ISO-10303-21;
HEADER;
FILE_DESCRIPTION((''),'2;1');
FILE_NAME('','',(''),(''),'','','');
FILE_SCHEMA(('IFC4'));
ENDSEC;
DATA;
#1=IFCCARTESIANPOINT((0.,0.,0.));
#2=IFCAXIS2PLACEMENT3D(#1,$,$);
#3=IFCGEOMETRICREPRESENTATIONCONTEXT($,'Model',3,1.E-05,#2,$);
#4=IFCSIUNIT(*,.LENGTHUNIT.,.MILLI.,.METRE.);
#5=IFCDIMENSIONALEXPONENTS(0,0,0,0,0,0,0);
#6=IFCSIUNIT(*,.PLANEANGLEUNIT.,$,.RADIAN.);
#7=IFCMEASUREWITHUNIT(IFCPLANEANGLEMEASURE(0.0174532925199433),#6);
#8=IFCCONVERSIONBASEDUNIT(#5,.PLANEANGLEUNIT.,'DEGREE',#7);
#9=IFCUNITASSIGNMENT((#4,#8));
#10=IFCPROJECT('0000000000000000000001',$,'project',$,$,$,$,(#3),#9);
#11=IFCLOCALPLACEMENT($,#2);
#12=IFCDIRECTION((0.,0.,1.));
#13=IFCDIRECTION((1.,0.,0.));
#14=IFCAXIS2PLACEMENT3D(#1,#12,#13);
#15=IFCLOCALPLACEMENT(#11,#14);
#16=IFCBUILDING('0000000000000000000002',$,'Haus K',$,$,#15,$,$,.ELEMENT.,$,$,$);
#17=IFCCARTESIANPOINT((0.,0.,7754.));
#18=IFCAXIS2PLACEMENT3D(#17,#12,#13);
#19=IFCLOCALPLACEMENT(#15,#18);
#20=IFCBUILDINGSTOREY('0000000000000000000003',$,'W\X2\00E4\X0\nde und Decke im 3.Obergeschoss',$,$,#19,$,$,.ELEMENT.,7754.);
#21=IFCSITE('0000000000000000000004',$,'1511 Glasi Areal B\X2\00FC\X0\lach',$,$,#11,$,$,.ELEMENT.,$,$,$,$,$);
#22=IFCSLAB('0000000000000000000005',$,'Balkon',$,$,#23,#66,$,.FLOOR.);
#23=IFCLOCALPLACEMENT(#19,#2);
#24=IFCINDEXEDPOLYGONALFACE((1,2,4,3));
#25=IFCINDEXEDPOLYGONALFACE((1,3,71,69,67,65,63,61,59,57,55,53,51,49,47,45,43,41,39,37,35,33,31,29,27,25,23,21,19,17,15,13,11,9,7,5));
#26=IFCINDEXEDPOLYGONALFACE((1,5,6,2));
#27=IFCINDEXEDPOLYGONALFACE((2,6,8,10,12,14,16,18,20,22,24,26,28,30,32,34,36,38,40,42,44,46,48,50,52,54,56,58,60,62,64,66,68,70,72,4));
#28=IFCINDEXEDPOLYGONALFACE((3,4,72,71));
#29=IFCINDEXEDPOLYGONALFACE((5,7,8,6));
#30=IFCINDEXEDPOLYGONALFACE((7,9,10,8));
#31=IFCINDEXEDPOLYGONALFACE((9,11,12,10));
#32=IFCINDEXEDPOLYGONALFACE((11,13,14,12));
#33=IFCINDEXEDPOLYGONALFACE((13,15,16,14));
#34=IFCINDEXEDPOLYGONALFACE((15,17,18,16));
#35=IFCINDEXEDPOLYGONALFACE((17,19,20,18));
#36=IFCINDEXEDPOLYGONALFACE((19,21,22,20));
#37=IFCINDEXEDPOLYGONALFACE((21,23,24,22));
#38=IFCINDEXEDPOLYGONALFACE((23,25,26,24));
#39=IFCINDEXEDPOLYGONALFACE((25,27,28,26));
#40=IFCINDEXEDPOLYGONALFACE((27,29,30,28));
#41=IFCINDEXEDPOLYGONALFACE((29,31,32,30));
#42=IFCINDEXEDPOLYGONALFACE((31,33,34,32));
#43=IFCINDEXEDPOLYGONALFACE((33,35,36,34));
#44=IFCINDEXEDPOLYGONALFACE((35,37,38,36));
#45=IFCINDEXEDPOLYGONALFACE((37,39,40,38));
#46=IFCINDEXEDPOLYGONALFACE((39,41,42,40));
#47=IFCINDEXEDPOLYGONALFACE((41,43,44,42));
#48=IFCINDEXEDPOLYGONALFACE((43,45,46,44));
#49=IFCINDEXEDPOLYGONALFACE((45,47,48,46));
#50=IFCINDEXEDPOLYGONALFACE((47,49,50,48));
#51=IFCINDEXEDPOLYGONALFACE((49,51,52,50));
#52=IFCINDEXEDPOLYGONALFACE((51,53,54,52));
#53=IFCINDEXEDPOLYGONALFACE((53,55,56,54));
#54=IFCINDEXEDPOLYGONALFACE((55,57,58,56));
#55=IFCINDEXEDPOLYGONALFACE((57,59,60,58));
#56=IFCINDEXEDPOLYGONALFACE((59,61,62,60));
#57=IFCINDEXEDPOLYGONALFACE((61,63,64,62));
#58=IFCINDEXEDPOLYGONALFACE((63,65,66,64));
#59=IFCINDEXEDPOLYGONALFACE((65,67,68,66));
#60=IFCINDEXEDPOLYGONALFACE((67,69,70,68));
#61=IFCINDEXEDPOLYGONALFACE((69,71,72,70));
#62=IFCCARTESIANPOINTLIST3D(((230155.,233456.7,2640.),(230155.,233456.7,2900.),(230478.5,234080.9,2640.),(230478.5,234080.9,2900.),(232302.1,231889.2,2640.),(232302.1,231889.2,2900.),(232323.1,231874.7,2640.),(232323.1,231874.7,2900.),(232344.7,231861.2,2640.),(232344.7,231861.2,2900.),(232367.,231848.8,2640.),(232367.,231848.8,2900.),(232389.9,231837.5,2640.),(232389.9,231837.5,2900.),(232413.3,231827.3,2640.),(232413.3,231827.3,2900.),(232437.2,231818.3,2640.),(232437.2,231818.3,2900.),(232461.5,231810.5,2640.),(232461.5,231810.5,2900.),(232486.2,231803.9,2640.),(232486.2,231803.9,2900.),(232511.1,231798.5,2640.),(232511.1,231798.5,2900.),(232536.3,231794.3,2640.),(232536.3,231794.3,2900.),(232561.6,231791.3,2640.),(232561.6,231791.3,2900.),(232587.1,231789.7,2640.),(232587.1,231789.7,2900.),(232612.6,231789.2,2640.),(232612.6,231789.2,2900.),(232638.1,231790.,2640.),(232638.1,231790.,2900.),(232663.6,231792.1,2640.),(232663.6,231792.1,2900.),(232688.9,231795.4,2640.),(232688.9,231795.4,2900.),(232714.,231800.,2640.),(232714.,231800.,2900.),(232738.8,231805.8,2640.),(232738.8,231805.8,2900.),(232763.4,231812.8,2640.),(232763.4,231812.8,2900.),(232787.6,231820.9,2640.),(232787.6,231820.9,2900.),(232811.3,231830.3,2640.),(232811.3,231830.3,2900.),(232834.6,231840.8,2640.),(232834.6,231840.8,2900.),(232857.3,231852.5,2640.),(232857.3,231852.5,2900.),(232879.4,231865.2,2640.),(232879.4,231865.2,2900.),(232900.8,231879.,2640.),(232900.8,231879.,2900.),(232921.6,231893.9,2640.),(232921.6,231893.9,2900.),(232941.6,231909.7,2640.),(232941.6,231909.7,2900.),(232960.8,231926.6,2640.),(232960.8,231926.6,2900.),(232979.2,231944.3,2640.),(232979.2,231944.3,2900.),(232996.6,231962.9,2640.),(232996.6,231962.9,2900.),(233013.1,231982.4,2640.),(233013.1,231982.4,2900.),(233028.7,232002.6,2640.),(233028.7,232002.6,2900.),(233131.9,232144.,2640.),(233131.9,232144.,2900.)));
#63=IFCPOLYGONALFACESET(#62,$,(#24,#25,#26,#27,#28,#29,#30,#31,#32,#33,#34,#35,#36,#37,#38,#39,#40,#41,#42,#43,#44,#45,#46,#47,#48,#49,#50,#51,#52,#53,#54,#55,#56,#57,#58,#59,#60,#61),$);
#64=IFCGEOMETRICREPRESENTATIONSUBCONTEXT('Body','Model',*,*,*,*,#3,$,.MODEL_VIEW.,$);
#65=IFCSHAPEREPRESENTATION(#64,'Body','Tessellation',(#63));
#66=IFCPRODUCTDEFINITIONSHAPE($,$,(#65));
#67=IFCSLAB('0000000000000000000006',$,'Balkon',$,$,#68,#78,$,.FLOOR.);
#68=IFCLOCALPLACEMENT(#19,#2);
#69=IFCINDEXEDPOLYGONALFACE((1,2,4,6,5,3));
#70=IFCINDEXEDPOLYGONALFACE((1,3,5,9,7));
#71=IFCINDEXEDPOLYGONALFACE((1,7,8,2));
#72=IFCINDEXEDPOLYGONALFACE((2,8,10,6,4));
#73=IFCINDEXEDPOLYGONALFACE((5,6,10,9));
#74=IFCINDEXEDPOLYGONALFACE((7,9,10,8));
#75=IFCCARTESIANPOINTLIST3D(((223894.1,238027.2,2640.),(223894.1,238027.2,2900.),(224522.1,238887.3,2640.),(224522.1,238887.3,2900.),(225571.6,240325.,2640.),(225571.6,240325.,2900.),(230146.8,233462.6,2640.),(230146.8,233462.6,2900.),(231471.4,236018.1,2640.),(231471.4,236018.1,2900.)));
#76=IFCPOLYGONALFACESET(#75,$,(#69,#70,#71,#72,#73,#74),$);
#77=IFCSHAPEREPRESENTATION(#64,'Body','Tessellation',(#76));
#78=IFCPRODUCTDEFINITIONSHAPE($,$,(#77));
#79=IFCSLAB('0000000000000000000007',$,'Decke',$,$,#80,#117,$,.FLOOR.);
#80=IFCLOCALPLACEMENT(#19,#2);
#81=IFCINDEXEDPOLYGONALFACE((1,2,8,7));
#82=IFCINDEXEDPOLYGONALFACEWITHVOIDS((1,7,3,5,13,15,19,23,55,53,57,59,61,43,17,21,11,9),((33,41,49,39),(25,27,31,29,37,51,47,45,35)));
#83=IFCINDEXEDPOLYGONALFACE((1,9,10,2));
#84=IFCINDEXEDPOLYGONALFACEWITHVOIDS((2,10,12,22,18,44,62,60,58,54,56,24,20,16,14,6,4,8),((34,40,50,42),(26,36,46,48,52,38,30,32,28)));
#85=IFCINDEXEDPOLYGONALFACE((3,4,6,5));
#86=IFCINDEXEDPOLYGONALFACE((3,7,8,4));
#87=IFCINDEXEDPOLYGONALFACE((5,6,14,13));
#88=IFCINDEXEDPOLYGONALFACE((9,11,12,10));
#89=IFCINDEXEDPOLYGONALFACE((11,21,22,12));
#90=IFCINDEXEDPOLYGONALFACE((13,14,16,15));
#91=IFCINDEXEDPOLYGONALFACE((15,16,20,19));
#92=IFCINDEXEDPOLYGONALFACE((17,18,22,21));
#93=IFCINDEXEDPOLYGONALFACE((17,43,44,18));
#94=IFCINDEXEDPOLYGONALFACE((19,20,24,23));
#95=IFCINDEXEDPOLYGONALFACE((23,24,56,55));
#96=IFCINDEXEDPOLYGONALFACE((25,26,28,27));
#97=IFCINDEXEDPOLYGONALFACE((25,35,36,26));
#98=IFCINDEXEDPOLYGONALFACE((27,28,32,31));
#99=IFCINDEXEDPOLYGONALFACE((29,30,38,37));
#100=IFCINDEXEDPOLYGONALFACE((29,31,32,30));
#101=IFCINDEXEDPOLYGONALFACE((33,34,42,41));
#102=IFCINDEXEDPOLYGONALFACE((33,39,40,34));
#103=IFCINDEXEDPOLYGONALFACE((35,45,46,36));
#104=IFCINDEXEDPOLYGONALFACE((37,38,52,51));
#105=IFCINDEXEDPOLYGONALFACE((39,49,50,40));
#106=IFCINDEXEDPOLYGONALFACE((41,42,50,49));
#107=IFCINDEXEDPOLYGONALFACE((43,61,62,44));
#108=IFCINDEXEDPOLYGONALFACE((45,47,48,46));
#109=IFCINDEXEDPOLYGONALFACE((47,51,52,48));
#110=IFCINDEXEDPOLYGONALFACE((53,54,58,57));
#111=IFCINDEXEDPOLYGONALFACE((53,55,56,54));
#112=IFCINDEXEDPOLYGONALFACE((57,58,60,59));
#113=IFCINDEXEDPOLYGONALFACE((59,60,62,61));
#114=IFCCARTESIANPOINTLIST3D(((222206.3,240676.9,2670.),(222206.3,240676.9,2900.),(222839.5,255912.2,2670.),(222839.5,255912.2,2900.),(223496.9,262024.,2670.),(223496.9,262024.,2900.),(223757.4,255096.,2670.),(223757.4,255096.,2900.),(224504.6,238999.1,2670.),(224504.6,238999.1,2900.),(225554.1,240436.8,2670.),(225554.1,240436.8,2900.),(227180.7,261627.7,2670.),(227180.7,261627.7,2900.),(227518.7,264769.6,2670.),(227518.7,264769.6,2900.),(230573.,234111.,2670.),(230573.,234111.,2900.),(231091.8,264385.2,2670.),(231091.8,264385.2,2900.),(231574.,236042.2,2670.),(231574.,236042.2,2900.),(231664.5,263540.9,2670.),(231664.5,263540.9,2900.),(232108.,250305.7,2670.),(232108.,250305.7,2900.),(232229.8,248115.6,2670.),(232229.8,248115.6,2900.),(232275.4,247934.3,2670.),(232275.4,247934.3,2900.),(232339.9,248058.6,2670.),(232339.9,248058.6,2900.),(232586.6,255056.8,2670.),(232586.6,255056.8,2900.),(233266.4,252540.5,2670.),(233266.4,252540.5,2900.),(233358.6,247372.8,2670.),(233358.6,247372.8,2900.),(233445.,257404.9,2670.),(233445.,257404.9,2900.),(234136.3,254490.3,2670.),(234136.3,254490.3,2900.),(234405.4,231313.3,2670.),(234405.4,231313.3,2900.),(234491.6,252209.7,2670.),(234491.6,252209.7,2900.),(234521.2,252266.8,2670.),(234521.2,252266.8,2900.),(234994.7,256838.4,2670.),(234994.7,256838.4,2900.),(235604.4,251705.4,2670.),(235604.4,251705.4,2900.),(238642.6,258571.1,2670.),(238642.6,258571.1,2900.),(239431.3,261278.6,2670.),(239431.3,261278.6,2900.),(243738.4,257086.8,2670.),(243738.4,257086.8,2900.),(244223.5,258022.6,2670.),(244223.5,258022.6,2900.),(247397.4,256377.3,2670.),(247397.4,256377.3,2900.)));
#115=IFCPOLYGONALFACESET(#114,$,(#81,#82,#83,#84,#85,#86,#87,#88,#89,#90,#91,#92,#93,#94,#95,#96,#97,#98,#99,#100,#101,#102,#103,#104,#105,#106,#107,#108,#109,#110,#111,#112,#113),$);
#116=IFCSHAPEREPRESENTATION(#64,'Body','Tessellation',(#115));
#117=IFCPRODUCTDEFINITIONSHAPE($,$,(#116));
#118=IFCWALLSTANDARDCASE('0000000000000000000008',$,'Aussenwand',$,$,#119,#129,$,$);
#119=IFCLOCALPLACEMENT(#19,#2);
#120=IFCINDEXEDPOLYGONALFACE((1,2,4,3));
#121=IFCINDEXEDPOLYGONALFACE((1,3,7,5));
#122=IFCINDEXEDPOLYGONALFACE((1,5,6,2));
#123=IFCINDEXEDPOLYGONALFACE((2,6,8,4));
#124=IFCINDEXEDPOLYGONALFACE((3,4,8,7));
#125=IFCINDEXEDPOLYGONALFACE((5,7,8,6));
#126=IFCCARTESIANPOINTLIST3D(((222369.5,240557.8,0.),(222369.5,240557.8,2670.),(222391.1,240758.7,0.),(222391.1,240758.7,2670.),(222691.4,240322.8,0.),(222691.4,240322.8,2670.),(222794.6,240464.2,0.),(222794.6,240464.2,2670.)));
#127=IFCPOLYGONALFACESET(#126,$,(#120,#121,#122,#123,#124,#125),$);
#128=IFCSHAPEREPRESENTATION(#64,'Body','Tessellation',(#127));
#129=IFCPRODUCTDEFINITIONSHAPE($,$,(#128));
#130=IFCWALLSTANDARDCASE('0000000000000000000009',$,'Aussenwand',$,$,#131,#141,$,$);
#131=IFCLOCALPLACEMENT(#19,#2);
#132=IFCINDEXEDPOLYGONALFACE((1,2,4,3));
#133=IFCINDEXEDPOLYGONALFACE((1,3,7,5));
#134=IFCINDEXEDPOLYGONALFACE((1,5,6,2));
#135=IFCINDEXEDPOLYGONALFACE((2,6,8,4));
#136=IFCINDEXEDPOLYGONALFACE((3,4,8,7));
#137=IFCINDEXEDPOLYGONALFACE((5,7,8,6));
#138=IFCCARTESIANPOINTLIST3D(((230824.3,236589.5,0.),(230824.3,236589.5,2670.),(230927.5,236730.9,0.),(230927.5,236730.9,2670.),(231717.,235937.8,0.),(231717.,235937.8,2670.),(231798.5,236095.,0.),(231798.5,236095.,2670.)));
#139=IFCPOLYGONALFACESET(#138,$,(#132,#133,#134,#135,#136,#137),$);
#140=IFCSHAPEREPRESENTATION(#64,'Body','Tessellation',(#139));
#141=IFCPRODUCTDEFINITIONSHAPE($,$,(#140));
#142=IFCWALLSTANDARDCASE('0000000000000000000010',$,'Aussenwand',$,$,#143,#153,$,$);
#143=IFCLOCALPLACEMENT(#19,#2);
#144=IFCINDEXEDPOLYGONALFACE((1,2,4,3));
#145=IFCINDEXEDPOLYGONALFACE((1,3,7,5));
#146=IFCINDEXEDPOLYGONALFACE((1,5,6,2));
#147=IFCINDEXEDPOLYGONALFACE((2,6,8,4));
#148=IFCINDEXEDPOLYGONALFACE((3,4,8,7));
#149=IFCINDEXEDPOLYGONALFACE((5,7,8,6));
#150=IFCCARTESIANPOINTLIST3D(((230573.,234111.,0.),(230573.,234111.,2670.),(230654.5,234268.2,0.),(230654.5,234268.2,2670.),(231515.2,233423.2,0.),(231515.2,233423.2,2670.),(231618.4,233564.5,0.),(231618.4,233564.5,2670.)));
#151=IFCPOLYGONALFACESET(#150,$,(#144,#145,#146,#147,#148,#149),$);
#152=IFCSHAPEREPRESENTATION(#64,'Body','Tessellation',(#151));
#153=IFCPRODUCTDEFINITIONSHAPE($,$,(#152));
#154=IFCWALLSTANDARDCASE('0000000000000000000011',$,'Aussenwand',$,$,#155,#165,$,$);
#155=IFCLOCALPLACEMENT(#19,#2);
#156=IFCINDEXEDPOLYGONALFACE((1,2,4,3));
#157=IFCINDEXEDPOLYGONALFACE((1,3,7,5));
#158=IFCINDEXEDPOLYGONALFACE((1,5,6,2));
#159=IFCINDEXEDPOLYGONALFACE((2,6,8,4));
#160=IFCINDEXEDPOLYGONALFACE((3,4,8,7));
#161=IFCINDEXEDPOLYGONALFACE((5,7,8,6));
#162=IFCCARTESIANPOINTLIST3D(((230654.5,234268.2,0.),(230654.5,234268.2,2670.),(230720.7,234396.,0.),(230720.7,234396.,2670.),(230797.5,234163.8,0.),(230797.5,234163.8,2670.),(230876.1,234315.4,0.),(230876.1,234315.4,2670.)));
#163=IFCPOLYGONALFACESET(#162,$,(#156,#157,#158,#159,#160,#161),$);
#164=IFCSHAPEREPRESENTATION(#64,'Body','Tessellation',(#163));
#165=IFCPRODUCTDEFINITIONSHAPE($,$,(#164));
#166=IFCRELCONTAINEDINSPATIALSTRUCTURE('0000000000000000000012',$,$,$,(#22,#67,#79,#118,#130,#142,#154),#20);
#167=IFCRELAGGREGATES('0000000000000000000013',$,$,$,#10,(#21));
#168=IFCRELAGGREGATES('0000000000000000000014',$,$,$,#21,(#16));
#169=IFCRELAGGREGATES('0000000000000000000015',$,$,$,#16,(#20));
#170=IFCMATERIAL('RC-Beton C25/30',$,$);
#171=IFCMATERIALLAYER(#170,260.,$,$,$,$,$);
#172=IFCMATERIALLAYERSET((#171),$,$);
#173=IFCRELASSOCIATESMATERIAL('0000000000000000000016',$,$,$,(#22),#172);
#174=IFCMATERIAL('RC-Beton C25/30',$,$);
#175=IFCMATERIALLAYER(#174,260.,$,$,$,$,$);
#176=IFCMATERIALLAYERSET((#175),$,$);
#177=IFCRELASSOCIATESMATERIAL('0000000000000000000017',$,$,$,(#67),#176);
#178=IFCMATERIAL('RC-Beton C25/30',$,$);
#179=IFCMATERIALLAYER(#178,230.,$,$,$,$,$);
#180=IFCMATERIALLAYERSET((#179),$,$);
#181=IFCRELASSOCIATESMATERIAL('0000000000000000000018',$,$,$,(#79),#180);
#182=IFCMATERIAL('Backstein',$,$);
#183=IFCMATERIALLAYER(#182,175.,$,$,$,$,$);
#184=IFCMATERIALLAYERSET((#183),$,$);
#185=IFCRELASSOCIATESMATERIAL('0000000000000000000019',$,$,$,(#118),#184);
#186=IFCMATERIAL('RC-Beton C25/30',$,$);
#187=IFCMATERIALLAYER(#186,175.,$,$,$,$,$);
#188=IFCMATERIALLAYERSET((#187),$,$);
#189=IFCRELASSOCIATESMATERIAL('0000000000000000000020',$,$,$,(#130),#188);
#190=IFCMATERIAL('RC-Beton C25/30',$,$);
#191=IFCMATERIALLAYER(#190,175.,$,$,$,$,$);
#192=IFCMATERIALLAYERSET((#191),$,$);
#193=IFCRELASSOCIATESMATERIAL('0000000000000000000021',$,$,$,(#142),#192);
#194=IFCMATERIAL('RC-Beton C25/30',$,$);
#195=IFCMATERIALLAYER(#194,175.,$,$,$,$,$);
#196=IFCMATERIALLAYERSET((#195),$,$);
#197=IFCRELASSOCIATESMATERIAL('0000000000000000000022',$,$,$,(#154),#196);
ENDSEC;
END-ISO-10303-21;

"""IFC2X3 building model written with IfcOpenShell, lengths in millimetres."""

from ifc_helpers import new_model, entity, si_unit, converted_unit, frame, frame_2d, origin, origin_with_axes, place, context, subcontext, project, spatial, polyline, rectangle, outline, extrude, material, layer, layer_set, layer_usage, element, save


model = new_model("IFC2X3")

# Units and contexts
model_context = context("Model", 3, precision=1e-05, world=origin())
body_context = subcontext(model_context, "Body", "Model", "MODEL_VIEW")
ifc_project = project(units=[si_unit("LENGTHUNIT", "METRE", prefix="MILLI"), converted_unit("PLANEANGLEUNIT", "DEGREE", entity("IfcPlaneAngleMeasure", 0.0174532925199433), si_unit("PLANEANGLEUNIT", "RADIAN"), dimensions=[0, 0, 0, 0, 0, 0, 0])], contexts=[model_context])

# Site, building, storey
site_placement = place(None, origin())
site = spatial("IfcSite", under=ifc_project, at=site_placement, Name="1511 Glasi Areal Bülach", CompositionType="ELEMENT")
building_placement = place(site_placement, origin_with_axes())
building = spatial("IfcBuilding", under=site, at=building_placement, Name="Haus K", CompositionType="ELEMENT")
storey_placement = place(building_placement, frame((0.0, 0.0, 7754.0), z_axis=(0.0, 0.0, 1.0), x_axis=(1.0, 0.0, 0.0)))
storey = spatial("IfcBuildingStorey", under=building, at=storey_placement, Name="Wände und Decke im 3.Obergeschoss", CompositionType="ELEMENT", Elevation=7754.0)

# Slabs
ifc_material_1 = material(Name="RC-Beton C25/30")
ifc_layer_1 = layer(ifc_material_1, 260.0)
ifc_layer_set_1 = layer_set([ifc_layer_1])
ifc_layer_usage_1 = layer_usage(ifc_layer_set_1, "AXIS3", "POSITIVE", 0.0)
slab_1_placement = place(storey_placement, frame((230155.0, 231789.2, 2640.0), z_axis=(0.0, 0.0, 1.0), x_axis=(1.0, 0.0, 0.0)))
element("IfcSlab", 1, at=slab_1_placement, inside=storey, material=ifc_layer_usage_1, Name="Balkon", PredefinedType="FLOOR", context=body_context, shape_type="SweptSolid", body=[
    extrude(outline(polyline([(2147.1, 100.0), (2168.1, 85.5), (2189.8, 72.0), (2212.1, 59.5), (2235.0, 48.2), (2258.4, 38.1), (2282.2, 29.1), (2306.5, 21.3), (2331.2, 14.6), (2356.1, 9.2), (2381.3, 5.1), (2406.7, 2.1), (2432.1, 0.4), (2457.7, 0.0), (2483.2, 0.8), (2508.6, 2.9), (2533.9, 6.2), (2559.0, 10.8), (2583.9, 16.5), (2608.4, 23.5), (2632.6, 31.7), (2656.3, 41.1), (2679.6, 51.6), (2702.3, 63.2), (2724.4, 76.0), (2745.9, 89.8), (2766.6, 104.7), (2786.6, 120.5), (2805.8, 137.3), (2824.2, 155.1), (2841.7, 173.7), (2858.2, 193.1), (2873.7, 213.4), (2976.9, 354.7), (323.6, 2291.7), (0.0, 1667.4), (2147.1, 100.0)])), origin_with_axes(), (0.0, 0.0, 1.0), 260.0),
])
ifc_material_2 = material(Name="RC-Beton C25/30")
ifc_layer_2 = layer(ifc_material_2, 260.0)
ifc_layer_set_2 = layer_set([ifc_layer_2])
ifc_layer_usage_2 = layer_usage(ifc_layer_set_2, "AXIS3", "POSITIVE", 0.0)
slab_2_placement = place(storey_placement, frame((223894.1, 233462.6, 2640.0), z_axis=(0.0, 0.0, 1.0), x_axis=(1.0, 0.0, 0.0)))
element("IfcSlab", 2, at=slab_2_placement, inside=storey, material=ifc_layer_usage_2, Name="Balkon", PredefinedType="FLOOR", context=body_context, shape_type="SweptSolid", body=[
    extrude(outline(polyline([(0.0, 4564.5), (6252.7, 0.0), (7577.3, 2555.4), (1677.5, 6862.4), (627.9, 5424.7), (0.0, 4564.5)])), origin_with_axes(), (0.0, 0.0, 1.0), 260.0),
])

# Slab, openings
ifc_material_3 = material(Name="RC-Beton C25/30")
ifc_layer_3 = layer(ifc_material_3, 230.0)
ifc_layer_set_3 = layer_set([ifc_layer_3])
ifc_layer_usage_3 = layer_usage(ifc_layer_set_3, "AXIS3", "POSITIVE", 0.0)
slab_3_placement = place(storey_placement, frame((222206.3, 231313.3, 2670.0), z_axis=(0.0, 0.0, 1.0), x_axis=(1.0, 0.0, 0.0)))
slab_3 = element("IfcSlab", 3, at=slab_3_placement, inside=storey, material=ifc_layer_usage_3, Name="Decke", PredefinedType="FLOOR", context=body_context, shape_type="SweptSolid", body=[
    extrude(outline(polyline([(22017.2, 26709.3), (21532.1, 25773.5), (16436.3, 27257.8), (17225.0, 29965.3), (9458.2, 32227.6), (8885.5, 33072.0), (5312.4, 33456.3), (4974.4, 30314.5), (1290.7, 30710.7), (633.2, 24598.9), (1551.1, 23782.8), (0.0, 9363.6), (2298.3, 7685.8), (3347.9, 9123.5), (9367.7, 4728.9), (8366.7, 2797.7), (12199.1, 0.0), (25191.1, 25064.1), (22017.2, 26709.3)])), origin_with_axes(), (0.0, 0.0, 1.0), 230.0),
])
opening_1_placement = place(slab_3_placement, frame((9901.7, 16059.5, 0.0), z_axis=(0.0, 0.0, 1.0), x_axis=(1.0, 0.0, 0.0)))
element("IfcOpeningElement", 4, at=opening_1_placement, cuts=slab_3, ObjectType="Opening", context=body_context, shape_type="SweptSolid", body=[
    extrude(outline(polyline([(2383.7, 4836.9), (1158.4, 5167.7), (0.0, 2932.8), (121.8, 742.8), (231.9, 685.7), (167.5, 561.4), (1250.6, 0.0), (3496.4, 4332.5), (2413.3, 4894.0), (2383.7, 4836.9)])), origin_with_axes(), (0.0, 0.0, 1.0), 230.0),
])
opening_2_placement = place(slab_3_placement, frame((11238.7, 26091.6, 0.0), z_axis=(0.0, 0.0, 1.0), x_axis=(1.0, 0.0, 0.0)))
element("IfcOpeningElement", 5, at=opening_2_placement, cuts=slab_3, ObjectType="Opening", context=body_context, shape_type="SweptSolid", body=[
    extrude(rectangle(XDim=2500.0, YDim=1650.0, at=frame_2d((345.7, -1457.3), x_axis=(-0.343332, -0.939214))), origin_with_axes(), (0.0, 0.0, 1.0), 230.0),
])

# Walls
ifc_material_4 = material(Name="Backstein")
ifc_layer_4 = layer(ifc_material_4, 175.0)
ifc_layer_set_4 = layer_set([ifc_layer_4])
ifc_layer_usage_4 = layer_usage(ifc_layer_set_4, "AXIS2", "POSITIVE", 0.0)
wall_1_placement = place(storey_placement, frame((222369.5, 240557.8, 0.0), z_axis=(0.0, 0.0, 1.0), x_axis=(0.807681, -0.589619, 0.0)))
element("IfcWallStandardCase", 6, at=wall_1_placement, inside=storey, material=ifc_layer_usage_4, Name="Aussenwand", context=body_context, shape_type="SweptSolid", body=[
    extrude(outline(polyline([(0.0, 0.0), (398.5, 0.0), (398.5, 175.0), (-101.0, 175.0), (0.0, 0.0)])), origin_with_axes(), (0.0, 0.0, 1.0), 2670.0),
])
ifc_material_5 = material(Name="RC-Beton C25/30")
ifc_layer_5 = layer(ifc_material_5, 175.0)
ifc_layer_set_5 = layer_set([ifc_layer_5])
ifc_layer_usage_5 = layer_usage(ifc_layer_set_5, "AXIS2", "POSITIVE", 0.0)
wall_2_placement = place(storey_placement, frame((230824.3, 236589.5, 0.0), z_axis=(0.0, 0.0, 1.0), x_axis=(0.807681, -0.589619, 0.0)))
element("IfcWallStandardCase", 7, at=wall_2_placement, inside=storey, material=ifc_layer_usage_5, Name="Aussenwand", context=body_context, shape_type="SweptSolid", body=[
    extrude(outline(polyline([(0.0, 0.0), (1105.3, 0.0), (1078.5, 175.0), (0.0, 175.0), (0.0, 0.0)])), origin_with_axes(), (0.0, 0.0, 1.0), 2670.0),
])
ifc_material_6 = material(Name="RC-Beton C25/30")
ifc_layer_6 = layer(ifc_material_6, 175.0)
ifc_layer_set_6 = layer_set([ifc_layer_6])
ifc_layer_usage_6 = layer_usage(ifc_layer_set_6, "AXIS2", "POSITIVE", 0.0)
wall_3_placement = place(storey_placement, frame((230573.0, 234111.0, 0.0), z_axis=(0.0, 0.0, 1.0), x_axis=(0.807681, -0.589619, 0.0)))
element("IfcWallStandardCase", 8, at=wall_3_placement, inside=storey, material=ifc_layer_usage_6, Name="Aussenwand", context=body_context, shape_type="SweptSolid", body=[
    extrude(outline(polyline([(0.0, 0.0), (1166.6, 0.0), (1166.6, 175.0), (-26.9, 175.0), (0.0, 0.0)])), origin_with_axes(), (0.0, 0.0, 1.0), 2670.0),
])
ifc_material_7 = material(Name="RC-Beton C25/30")
ifc_layer_7 = layer(ifc_material_7, 175.0)
ifc_layer_set_7 = layer_set([ifc_layer_7])
ifc_layer_usage_7 = layer_usage(ifc_layer_set_7, "AXIS2", "POSITIVE", 0.0)
wall_4_placement = place(storey_placement, frame((230720.7, 234396.0, 0.0), z_axis=(0.0, 0.0, 1.0), x_axis=(-0.4602, -0.887815, 0.0)))
element("IfcWallStandardCase", 9, at=wall_4_placement, inside=storey, material=ifc_layer_usage_7, Name="Aussenwand", context=body_context, shape_type="SweptSolid", body=[
    extrude(outline(polyline([(0.0, 0.0), (143.9, 0.0), (170.8, 175.0), (0.0, 175.0), (0.0, 0.0)])), origin_with_axes(), (0.0, 0.0, 1.0), 2670.0),
])

save(model, "model.ifc")
